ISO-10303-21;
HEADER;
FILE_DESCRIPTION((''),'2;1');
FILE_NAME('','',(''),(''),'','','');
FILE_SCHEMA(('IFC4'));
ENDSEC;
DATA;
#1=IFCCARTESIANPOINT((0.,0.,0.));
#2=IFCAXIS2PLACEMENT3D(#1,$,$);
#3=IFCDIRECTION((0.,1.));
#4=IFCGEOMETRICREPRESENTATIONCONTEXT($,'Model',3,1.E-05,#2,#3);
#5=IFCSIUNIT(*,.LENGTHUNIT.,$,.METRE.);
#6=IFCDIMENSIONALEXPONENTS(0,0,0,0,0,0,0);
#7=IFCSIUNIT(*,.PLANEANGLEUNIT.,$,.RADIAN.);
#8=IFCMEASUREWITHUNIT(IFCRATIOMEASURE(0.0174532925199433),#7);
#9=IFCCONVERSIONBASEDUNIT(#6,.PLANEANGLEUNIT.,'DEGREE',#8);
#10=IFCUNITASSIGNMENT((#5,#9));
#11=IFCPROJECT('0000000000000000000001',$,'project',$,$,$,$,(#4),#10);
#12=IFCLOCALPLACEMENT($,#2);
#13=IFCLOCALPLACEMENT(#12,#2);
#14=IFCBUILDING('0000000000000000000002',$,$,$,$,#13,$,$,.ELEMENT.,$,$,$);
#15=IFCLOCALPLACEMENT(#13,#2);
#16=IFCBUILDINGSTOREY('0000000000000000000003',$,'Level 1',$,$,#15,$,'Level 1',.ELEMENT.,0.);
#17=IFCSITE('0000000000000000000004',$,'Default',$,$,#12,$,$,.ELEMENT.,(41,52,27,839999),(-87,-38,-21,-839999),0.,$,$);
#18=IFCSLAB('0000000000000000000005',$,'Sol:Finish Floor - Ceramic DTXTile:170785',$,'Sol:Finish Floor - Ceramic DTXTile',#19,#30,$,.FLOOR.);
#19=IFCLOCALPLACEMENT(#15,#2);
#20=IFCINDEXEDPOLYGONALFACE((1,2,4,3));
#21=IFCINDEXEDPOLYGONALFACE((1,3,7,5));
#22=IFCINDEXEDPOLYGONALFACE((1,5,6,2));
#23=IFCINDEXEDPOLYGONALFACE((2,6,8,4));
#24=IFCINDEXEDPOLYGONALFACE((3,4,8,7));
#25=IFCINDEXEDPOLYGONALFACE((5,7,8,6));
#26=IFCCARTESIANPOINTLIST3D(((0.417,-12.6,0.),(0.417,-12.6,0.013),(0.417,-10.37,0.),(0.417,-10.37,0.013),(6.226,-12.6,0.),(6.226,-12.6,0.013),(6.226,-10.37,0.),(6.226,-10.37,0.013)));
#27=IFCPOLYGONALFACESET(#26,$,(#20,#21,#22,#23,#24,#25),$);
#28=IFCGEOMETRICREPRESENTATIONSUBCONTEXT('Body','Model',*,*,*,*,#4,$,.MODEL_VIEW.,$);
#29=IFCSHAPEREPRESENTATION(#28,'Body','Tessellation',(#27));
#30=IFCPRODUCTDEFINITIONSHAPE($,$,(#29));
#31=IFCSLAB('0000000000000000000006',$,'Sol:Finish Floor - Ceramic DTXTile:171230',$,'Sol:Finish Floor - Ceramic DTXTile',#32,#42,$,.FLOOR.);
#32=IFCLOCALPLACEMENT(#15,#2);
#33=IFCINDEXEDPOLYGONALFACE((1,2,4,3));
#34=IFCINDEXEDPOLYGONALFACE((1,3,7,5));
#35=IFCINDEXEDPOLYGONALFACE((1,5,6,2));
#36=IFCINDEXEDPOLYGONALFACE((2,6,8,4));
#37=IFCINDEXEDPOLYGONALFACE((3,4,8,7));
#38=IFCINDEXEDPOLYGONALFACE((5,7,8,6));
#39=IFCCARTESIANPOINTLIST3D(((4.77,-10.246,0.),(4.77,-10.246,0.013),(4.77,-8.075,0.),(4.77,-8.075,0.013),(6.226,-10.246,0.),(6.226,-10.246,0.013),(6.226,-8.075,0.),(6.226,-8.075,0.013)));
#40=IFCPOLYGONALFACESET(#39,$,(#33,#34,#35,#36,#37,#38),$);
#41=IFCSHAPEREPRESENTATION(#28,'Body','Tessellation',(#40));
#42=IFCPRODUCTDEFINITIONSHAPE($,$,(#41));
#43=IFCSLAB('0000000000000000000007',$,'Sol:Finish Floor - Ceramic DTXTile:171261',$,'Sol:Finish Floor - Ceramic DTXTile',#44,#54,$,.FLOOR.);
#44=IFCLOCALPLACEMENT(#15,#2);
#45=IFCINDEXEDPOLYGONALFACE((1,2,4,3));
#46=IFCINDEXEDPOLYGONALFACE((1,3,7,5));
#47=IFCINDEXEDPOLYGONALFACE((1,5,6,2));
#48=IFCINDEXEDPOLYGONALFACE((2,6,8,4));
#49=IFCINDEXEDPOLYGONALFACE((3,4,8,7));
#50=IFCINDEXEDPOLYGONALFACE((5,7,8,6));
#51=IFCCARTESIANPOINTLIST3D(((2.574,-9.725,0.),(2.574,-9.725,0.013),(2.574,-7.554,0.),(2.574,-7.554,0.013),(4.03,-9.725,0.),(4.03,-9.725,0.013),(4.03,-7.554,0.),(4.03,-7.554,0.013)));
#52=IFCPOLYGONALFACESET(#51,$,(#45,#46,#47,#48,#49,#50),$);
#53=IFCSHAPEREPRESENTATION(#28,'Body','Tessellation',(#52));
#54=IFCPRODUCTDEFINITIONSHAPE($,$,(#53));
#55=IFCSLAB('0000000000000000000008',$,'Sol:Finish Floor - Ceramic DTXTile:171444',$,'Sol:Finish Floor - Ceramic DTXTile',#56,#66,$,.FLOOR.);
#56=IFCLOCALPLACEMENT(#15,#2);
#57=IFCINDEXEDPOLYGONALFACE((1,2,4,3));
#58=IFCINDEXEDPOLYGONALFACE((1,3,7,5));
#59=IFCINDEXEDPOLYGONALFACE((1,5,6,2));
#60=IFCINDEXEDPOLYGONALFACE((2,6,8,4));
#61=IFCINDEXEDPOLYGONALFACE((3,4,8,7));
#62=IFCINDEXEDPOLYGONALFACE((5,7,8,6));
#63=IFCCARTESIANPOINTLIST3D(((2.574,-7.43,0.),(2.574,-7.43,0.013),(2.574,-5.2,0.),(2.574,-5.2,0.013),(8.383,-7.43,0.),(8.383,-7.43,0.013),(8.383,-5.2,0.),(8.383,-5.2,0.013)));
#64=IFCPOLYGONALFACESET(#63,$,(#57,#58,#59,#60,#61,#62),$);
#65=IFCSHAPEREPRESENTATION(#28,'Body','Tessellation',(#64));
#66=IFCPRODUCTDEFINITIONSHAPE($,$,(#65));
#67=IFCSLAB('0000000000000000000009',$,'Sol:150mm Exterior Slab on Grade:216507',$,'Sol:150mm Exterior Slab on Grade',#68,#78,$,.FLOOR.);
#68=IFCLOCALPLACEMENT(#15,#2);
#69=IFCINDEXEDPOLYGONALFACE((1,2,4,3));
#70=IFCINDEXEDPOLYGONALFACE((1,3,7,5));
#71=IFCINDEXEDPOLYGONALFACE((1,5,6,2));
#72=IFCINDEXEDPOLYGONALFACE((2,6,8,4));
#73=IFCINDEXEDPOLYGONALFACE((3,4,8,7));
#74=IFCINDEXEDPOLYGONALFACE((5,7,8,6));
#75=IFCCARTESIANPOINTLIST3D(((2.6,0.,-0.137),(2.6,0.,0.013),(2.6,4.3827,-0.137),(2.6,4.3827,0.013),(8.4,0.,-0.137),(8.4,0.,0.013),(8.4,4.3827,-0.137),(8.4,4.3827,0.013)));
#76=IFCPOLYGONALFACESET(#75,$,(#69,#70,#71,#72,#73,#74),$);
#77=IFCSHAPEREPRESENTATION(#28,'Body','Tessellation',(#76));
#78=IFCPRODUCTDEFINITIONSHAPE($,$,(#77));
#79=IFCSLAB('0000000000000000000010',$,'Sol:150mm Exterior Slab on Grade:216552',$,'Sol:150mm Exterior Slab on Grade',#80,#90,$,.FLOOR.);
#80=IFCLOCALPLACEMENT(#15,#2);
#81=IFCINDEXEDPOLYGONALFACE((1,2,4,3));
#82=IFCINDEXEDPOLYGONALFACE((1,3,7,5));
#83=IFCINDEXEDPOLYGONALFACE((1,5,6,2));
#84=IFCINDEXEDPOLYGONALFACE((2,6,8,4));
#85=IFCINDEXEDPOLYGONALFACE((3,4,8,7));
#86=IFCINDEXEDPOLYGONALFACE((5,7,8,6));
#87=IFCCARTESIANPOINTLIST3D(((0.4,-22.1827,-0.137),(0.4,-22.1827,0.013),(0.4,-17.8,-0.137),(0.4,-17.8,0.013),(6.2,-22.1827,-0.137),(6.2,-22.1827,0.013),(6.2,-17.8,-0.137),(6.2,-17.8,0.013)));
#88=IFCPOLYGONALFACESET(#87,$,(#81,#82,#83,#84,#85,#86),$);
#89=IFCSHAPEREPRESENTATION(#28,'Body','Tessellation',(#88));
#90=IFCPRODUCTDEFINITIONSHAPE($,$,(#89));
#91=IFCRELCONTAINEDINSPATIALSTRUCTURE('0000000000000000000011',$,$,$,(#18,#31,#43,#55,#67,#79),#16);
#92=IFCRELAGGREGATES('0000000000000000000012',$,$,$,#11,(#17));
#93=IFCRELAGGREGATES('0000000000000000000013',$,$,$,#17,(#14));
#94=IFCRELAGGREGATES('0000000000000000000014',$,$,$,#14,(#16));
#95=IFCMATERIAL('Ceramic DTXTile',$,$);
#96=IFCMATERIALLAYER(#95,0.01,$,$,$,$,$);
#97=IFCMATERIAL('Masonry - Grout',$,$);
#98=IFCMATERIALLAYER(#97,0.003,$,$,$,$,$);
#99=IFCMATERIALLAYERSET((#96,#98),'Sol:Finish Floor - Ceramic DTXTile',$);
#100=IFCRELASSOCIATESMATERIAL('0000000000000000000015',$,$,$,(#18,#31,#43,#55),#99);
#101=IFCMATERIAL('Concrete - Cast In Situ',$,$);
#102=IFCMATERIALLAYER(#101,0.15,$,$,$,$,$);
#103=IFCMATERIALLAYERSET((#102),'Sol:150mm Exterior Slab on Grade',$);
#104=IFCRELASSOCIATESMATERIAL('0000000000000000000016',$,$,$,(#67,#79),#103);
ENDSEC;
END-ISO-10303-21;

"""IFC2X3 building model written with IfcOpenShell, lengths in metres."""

from ifc_helpers import new_model, entity, si_unit, converted_unit, direction, frame, frame_2d, origin, place, context, subcontext, project, spatial, rectangle, extrude, material, layer, layer_set, layer_usage, element, save


model = new_model("IFC2X3")

# Units and contexts
model_context = context("Model", 3, precision=1e-05, world=origin(), true_north=direction((0.0, 1.0)))
body_context = subcontext(model_context, "Body", "Model", "MODEL_VIEW")
ifc_project = project(units=[si_unit("LENGTHUNIT", "METRE"), converted_unit("PLANEANGLEUNIT", "DEGREE", entity("IfcRatioMeasure", 0.0174532925199433), si_unit("PLANEANGLEUNIT", "RADIAN"), dimensions=[0, 0, 0, 0, 0, 0, 0])], contexts=[model_context])

# Site, building, storey
site_placement = place(None, origin())
site = spatial("IfcSite", under=ifc_project, at=site_placement, Name="Default", CompositionType="ELEMENT", RefLatitude=(41, 52, 27, 839999), RefLongitude=(-87, -38, -21, -839999), RefElevation=0.0)
building_placement = place(site_placement, origin())
building = spatial("IfcBuilding", under=site, at=building_placement, CompositionType="ELEMENT")
storey_placement = place(building_placement, origin())
storey = spatial("IfcBuildingStorey", under=building, at=storey_placement, Name="Level 1", LongName="Level 1", CompositionType="ELEMENT", Elevation=0.0)

# Slabs
ifc_material_1 = material(Name="Ceramic DTXTile")
ifc_layer_1 = layer(ifc_material_1, 0.01)
ifc_material_2 = material(Name="Masonry - Grout")
ifc_layer_2 = layer(ifc_material_2, 0.003)
ifc_layer_set_1 = layer_set([ifc_layer_1, ifc_layer_2], Name="Sol:Finish Floor - Ceramic DTXTile")
ifc_layer_usage_1 = layer_usage(ifc_layer_set_1, "AXIS3", "POSITIVE", 0.0)
slab_1_placement = place(storey_placement, origin())
element("IfcSlab", 1, at=slab_1_placement, inside=storey, material=ifc_layer_usage_1, Name="Sol:Finish Floor - Ceramic DTXTile:170785", ObjectType="Sol:Finish Floor - Ceramic DTXTile", PredefinedType="FLOOR", context=body_context, shape_type="SweptSolid", body=[
    extrude(rectangle(XDim=2.23, YDim=5.809, at=frame_2d((0.0, 0.0), x_axis=(1.0, 0.0))), frame((3.3215, -11.485, 0.013), z_axis=(0.0, 0.0, -1.0), x_axis=(0.0, 1.0, 0.0)), (0.0, 0.0, 1.0), 0.013),
])
ifc_layer_usage_2 = layer_usage(ifc_layer_set_1, "AXIS3", "POSITIVE", 0.0)
slab_2_placement = place(storey_placement, origin())
element("IfcSlab", 2, at=slab_2_placement, inside=storey, material=ifc_layer_usage_2, Name="Sol:Finish Floor - Ceramic DTXTile:171230", ObjectType="Sol:Finish Floor - Ceramic DTXTile", PredefinedType="FLOOR", context=body_context, shape_type="SweptSolid", body=[
    extrude(rectangle(XDim=2.171, YDim=1.456, at=frame_2d((0.0, 0.0), x_axis=(1.0, 0.0))), frame((5.498, -9.1605, 0.013), z_axis=(0.0, 0.0, -1.0), x_axis=(0.0, 1.0, 0.0)), (0.0, 0.0, 1.0), 0.013),
])
ifc_layer_usage_3 = layer_usage(ifc_layer_set_1, "AXIS3", "POSITIVE", 0.0)
slab_3_placement = place(storey_placement, origin())
element("IfcSlab", 3, at=slab_3_placement, inside=storey, material=ifc_layer_usage_3, Name="Sol:Finish Floor - Ceramic DTXTile:171261", ObjectType="Sol:Finish Floor - Ceramic DTXTile", PredefinedType="FLOOR", context=body_context, shape_type="SweptSolid", body=[
    extrude(rectangle(XDim=2.171, YDim=1.456, at=frame_2d((0.0, 0.0), x_axis=(1.0, 0.0))), frame((3.302, -8.6395, 0.013), z_axis=(0.0, 0.0, -1.0), x_axis=(0.0, 1.0, 0.0)), (0.0, 0.0, 1.0), 0.013),
])
ifc_layer_usage_4 = layer_usage(ifc_layer_set_1, "AXIS3", "POSITIVE", 0.0)
slab_4_placement = place(storey_placement, origin())
element("IfcSlab", 4, at=slab_4_placement, inside=storey, material=ifc_layer_usage_4, Name="Sol:Finish Floor - Ceramic DTXTile:171444", ObjectType="Sol:Finish Floor - Ceramic DTXTile", PredefinedType="FLOOR", context=body_context, shape_type="SweptSolid", body=[
    extrude(rectangle(XDim=2.23, YDim=5.809, at=frame_2d((0.0, 0.0), x_axis=(1.0, 0.0))), frame((5.4785, -6.315, 0.013), z_axis=(0.0, 0.0, -1.0), x_axis=(0.0, 1.0, 0.0)), (0.0, 0.0, 1.0), 0.013),
])
ifc_material_3 = material(Name="Concrete - Cast In Situ")
ifc_layer_3 = layer(ifc_material_3, 0.15)
ifc_layer_set_2 = layer_set([ifc_layer_3], Name="Sol:150mm Exterior Slab on Grade")
ifc_layer_usage_5 = layer_usage(ifc_layer_set_2, "AXIS3", "POSITIVE", 0.0)
slab_5_placement = place(storey_placement, origin())
element("IfcSlab", 5, at=slab_5_placement, inside=storey, material=ifc_layer_usage_5, Name="Sol:150mm Exterior Slab on Grade:216507", ObjectType="Sol:150mm Exterior Slab on Grade", PredefinedType="FLOOR", context=body_context, shape_type="SweptSolid", body=[
    extrude(rectangle(XDim=4.3827, YDim=5.8, at=frame_2d((0.0, 0.0), x_axis=(1.0, 0.0))), frame((5.5, 2.1914, 0.013), z_axis=(0.0, 0.0, -1.0), x_axis=(0.0, 1.0, 0.0)), (0.0, 0.0, 1.0), 0.15),
])
ifc_layer_usage_6 = layer_usage(ifc_layer_set_2, "AXIS3", "POSITIVE", 0.0)
slab_6_placement = place(storey_placement, origin())
element("IfcSlab", 6, at=slab_6_placement, inside=storey, material=ifc_layer_usage_6, Name="Sol:150mm Exterior Slab on Grade:216552", ObjectType="Sol:150mm Exterior Slab on Grade", PredefinedType="FLOOR", context=body_context, shape_type="SweptSolid", body=[
    extrude(rectangle(XDim=4.3827, YDim=5.8, at=frame_2d((0.0, 0.0), x_axis=(1.0, 0.0))), frame((3.3, -19.9914, 0.013), z_axis=(0.0, 0.0, -1.0), x_axis=(0.0, 1.0, 0.0)), (0.0, 0.0, 1.0), 0.15),
])

save(model, "model.ifc")
